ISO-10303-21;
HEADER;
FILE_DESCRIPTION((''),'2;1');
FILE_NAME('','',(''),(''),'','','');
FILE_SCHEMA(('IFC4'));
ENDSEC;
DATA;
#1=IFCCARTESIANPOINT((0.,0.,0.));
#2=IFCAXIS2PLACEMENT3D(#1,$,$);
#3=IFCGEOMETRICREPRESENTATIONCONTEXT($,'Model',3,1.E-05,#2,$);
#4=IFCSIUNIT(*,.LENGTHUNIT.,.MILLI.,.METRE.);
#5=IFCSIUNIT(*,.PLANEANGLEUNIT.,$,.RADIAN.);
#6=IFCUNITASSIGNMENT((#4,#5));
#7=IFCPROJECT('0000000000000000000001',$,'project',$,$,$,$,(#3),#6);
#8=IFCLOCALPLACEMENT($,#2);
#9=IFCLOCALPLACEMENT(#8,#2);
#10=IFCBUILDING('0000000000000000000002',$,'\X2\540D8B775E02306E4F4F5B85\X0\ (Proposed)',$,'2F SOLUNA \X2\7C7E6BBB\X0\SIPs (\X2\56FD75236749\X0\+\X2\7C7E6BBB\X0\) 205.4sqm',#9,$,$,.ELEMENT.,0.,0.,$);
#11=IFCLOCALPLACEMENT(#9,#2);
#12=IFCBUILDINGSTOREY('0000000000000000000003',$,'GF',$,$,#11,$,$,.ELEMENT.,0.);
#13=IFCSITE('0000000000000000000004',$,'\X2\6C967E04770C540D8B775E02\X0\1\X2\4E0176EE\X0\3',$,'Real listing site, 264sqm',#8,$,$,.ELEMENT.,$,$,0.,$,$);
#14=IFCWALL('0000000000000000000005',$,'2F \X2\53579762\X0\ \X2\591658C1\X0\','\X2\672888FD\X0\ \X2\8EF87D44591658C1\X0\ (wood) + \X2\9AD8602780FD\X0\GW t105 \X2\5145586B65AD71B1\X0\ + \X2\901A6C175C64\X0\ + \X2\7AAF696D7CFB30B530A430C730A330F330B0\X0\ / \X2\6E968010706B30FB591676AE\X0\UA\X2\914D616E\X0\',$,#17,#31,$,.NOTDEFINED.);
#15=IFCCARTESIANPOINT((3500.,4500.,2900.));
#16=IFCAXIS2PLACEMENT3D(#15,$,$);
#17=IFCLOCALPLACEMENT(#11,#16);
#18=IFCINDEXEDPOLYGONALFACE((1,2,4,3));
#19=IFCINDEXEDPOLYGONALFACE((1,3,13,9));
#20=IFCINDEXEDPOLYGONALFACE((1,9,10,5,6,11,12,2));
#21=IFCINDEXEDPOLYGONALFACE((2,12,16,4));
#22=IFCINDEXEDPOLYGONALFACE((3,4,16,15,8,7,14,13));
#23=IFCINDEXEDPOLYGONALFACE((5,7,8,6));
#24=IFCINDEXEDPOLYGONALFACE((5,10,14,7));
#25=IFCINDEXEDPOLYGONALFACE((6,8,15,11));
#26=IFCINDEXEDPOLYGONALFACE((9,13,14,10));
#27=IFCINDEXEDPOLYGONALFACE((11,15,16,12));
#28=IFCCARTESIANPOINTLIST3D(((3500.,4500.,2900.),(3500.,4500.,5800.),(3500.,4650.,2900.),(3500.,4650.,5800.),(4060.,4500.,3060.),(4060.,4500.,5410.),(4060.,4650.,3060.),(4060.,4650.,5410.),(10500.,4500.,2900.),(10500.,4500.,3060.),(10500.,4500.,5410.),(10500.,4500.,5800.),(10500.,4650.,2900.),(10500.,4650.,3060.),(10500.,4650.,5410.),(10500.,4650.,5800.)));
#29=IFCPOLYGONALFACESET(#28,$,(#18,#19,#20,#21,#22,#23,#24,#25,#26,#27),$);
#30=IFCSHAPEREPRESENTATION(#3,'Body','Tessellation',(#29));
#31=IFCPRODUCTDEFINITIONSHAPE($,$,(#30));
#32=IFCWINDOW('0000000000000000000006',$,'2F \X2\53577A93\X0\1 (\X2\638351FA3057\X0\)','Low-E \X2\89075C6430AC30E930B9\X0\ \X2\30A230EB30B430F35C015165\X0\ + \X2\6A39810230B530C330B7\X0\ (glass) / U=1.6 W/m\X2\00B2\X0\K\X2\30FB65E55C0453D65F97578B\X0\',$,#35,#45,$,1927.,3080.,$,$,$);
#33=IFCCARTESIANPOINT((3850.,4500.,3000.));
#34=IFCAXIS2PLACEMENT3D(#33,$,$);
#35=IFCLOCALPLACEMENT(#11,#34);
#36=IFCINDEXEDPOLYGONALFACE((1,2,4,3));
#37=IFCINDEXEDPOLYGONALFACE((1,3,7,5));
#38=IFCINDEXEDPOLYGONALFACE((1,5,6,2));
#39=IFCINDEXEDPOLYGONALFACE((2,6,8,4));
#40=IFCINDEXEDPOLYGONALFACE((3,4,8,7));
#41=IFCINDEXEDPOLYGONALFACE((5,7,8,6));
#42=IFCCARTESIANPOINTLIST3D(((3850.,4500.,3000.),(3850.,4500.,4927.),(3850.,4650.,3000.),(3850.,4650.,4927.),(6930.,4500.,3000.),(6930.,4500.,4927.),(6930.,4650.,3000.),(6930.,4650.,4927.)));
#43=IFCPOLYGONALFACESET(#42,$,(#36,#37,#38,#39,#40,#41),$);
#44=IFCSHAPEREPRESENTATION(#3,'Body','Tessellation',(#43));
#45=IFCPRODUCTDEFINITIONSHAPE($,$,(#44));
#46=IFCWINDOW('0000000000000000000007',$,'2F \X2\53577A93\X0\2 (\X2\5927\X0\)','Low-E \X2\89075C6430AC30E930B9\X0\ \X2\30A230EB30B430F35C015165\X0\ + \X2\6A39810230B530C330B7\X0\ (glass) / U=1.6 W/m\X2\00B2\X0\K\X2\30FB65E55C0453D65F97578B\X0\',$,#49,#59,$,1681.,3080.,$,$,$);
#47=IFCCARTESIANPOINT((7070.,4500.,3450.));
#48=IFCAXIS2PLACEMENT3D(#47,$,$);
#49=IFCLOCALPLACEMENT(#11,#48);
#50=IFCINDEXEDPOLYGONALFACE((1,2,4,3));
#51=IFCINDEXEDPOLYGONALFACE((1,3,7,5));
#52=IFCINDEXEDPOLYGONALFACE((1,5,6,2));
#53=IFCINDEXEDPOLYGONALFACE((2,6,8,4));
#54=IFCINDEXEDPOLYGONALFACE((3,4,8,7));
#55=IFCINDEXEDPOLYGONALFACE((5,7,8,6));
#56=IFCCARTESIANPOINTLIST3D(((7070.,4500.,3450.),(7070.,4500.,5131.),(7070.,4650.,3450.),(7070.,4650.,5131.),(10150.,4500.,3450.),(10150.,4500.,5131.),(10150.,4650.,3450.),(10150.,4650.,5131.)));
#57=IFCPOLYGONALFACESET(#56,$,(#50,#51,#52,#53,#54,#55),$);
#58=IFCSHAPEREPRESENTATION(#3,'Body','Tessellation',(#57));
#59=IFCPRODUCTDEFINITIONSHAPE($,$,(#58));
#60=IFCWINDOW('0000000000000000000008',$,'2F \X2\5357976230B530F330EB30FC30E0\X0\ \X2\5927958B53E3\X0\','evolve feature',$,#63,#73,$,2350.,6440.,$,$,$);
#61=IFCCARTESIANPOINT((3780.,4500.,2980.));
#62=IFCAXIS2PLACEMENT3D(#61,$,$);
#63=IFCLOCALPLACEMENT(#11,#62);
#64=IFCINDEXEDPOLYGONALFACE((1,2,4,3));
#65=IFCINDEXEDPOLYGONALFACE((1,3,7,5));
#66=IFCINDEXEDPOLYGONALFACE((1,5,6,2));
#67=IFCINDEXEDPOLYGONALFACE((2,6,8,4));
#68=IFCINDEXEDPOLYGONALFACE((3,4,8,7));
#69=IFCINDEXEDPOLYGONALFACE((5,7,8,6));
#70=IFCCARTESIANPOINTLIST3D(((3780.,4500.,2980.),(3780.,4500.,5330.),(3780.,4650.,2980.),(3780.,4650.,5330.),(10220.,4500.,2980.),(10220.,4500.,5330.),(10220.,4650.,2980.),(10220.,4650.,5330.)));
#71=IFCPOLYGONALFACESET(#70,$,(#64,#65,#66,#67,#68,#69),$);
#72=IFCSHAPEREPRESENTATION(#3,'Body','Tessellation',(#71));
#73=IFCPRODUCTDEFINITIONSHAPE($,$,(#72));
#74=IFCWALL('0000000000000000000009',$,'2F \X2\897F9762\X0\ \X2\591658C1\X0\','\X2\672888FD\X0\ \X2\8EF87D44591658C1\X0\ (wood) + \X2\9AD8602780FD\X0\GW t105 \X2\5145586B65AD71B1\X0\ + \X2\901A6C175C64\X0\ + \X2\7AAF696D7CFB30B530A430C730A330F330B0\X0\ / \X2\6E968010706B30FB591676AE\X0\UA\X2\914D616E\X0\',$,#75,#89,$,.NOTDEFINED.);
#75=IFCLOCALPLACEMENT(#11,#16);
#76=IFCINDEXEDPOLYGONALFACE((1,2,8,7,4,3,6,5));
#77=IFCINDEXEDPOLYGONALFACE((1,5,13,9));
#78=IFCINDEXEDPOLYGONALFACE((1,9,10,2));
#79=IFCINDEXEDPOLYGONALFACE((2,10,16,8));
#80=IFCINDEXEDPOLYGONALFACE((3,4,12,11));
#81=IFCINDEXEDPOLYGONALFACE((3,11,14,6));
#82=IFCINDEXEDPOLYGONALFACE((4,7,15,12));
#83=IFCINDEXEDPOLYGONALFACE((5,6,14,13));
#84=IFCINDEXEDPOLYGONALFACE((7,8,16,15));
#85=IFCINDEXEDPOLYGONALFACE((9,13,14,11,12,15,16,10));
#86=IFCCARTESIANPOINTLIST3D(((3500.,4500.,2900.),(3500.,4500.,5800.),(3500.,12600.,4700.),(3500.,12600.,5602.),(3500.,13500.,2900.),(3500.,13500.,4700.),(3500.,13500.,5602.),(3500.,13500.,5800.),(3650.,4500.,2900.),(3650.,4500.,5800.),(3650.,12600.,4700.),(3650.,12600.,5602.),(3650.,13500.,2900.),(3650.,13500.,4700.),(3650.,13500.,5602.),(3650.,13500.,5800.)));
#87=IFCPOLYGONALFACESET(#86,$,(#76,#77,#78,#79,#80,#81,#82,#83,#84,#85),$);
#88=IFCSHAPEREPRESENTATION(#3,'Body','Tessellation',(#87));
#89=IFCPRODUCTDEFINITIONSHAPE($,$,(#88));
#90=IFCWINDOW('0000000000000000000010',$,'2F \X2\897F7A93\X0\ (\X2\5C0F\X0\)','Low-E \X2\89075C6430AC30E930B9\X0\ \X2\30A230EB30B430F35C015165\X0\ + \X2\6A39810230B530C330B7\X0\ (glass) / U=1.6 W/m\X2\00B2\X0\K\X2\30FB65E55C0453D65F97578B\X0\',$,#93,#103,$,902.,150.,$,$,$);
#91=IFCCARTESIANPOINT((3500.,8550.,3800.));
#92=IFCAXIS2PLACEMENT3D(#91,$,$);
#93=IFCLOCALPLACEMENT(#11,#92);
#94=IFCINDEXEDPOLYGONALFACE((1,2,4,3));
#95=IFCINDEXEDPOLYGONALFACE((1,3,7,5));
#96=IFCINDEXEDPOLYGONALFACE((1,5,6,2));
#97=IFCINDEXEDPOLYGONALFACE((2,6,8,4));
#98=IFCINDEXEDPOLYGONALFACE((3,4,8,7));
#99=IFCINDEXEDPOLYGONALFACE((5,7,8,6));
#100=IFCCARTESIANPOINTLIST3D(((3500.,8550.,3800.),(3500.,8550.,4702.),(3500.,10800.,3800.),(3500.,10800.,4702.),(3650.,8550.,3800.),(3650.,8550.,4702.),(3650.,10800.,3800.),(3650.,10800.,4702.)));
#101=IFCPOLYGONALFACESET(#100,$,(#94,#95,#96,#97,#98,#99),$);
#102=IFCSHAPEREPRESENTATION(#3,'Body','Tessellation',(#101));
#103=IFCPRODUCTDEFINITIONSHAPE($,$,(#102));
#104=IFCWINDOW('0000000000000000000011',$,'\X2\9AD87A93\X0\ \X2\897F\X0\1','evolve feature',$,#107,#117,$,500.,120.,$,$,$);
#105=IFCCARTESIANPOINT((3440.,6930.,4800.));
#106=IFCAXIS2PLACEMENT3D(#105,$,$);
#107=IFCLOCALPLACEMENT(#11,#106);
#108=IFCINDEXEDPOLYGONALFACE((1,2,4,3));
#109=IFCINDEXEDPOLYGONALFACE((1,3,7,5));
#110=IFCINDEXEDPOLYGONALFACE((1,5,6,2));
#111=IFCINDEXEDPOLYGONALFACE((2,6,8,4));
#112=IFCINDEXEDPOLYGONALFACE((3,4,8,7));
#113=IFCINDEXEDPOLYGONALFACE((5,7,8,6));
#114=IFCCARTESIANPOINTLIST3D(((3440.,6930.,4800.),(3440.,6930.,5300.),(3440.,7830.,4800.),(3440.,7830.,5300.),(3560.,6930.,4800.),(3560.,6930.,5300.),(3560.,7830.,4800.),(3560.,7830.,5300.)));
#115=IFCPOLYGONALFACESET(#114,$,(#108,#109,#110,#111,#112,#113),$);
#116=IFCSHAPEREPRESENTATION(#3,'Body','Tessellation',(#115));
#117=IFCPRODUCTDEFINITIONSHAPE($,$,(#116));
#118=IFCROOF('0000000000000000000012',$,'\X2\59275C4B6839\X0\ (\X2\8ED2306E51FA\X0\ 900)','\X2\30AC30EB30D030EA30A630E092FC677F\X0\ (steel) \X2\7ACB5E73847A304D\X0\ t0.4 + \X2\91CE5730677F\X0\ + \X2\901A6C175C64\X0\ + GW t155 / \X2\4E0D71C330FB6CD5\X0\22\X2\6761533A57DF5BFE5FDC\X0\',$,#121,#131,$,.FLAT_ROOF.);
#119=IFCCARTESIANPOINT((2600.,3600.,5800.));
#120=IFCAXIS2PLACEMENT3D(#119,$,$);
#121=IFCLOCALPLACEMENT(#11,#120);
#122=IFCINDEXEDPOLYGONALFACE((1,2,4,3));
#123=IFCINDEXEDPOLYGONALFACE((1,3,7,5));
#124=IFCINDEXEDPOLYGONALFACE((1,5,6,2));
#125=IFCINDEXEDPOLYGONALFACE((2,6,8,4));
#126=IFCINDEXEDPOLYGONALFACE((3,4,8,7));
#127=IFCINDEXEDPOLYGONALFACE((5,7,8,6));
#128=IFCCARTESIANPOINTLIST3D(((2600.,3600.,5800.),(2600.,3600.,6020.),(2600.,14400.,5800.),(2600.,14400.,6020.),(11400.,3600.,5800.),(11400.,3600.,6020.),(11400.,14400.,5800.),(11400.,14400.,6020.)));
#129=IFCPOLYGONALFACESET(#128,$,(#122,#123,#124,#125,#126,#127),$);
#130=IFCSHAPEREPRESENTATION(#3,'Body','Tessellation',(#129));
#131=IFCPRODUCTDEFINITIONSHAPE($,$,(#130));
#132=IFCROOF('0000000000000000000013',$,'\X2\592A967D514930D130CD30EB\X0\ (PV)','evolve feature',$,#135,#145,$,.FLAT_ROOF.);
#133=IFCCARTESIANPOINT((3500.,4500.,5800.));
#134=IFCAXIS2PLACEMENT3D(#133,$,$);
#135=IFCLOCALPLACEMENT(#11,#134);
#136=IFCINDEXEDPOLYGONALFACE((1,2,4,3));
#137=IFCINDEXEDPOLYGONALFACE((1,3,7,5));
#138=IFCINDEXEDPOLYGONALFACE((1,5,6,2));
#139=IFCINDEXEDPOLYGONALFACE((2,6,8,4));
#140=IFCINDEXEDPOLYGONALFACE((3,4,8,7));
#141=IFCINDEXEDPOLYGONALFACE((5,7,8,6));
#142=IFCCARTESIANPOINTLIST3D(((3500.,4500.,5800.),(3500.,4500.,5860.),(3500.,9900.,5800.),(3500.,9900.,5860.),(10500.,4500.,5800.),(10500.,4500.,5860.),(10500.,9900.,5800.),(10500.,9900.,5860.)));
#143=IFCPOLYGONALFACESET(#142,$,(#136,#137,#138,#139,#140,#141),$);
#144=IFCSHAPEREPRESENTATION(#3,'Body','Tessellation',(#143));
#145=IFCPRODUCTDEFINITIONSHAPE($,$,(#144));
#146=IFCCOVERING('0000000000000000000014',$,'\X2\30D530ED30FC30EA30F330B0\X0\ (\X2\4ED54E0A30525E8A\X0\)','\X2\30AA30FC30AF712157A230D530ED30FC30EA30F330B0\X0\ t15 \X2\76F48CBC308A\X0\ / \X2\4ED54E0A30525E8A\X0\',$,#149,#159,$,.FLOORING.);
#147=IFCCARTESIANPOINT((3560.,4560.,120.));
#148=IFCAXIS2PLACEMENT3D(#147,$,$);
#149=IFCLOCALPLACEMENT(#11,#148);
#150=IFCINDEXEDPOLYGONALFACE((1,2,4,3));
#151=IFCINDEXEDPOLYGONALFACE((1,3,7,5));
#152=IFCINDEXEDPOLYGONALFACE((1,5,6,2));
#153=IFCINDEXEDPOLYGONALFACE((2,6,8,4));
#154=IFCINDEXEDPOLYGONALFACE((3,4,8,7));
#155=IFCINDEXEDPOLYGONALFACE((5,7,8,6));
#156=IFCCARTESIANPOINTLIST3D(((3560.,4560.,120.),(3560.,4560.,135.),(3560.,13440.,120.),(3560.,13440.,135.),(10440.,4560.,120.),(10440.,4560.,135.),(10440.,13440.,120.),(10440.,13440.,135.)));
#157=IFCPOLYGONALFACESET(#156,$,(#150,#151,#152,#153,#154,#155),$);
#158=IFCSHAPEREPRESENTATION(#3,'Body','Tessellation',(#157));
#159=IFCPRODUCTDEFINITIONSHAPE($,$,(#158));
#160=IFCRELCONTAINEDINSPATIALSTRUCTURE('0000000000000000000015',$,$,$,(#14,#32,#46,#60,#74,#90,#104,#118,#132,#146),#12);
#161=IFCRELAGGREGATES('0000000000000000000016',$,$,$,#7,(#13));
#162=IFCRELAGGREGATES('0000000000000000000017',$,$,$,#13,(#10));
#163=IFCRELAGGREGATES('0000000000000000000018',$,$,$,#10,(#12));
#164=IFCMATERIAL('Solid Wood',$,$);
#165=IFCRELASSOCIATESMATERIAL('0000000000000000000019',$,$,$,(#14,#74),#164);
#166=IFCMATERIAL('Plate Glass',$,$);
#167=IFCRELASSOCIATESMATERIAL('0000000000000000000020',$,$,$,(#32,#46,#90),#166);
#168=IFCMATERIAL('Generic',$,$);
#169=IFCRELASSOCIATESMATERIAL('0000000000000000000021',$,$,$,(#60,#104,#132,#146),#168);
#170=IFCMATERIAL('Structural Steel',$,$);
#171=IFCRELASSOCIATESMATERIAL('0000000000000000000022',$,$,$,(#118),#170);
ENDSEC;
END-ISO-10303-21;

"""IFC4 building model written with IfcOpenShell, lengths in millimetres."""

from ifc_helpers import new_model, si_unit, frame, frame_2d, origin, place, context, project, spatial, rectangle, extrude, material, element, fill, save


model = new_model("IFC4")

# Units and contexts
model_context = context("Model", 3, precision=1e-05, world=origin())
ifc_project = project(units=[si_unit("LENGTHUNIT", "METRE", prefix="MILLI"), si_unit("PLANEANGLEUNIT", "RADIAN")], contexts=[model_context])

# Site, building, storey
site_placement = place(None, origin())
site = spatial("IfcSite", under=ifc_project, at=site_placement, Name="沖縄県名護市1丁目3", ObjectType="Real listing site, 264sqm", CompositionType="ELEMENT", RefElevation=0.0)
building_placement = place(site_placement, origin())
building = spatial("IfcBuilding", under=site, at=building_placement, Name="名護市の住宅 (Proposed)", ObjectType="2F SOLUNA 籾殻SIPs (国産杉+籾殻) 205.4sqm", CompositionType="ELEMENT", ElevationOfRefHeight=0.0, ElevationOfTerrain=0.0)
storey_placement = place(building_placement, origin())
storey = spatial("IfcBuildingStorey", under=building, at=storey_placement, Name="GF", CompositionType="ELEMENT", Elevation=0.0)

# Shared definitions
ifc_material_1 = material(Name="Solid Wood")

# Shared definitions
ifc_material_2 = material(Name="Plate Glass")
ifc_material_3 = material(Name="Generic")

# Walls, openings, windows
wall_1_placement = place(storey_placement, frame((3500.0, 4500.0, 2900.0)))
wall_1 = element("IfcWall", 1, at=wall_1_placement, inside=storey, material=ifc_material_1, Name="2F 南面 外壁", Description="木製 軸組外壁 (wood) + 高性能GW t105 充填断熱 + 通気層 + 窯業系サイディング / 準耐火・外皮UA配慮", PredefinedType="NOTDEFINED", context=model_context, shape_type="SweptSolid", body=[
    extrude(rectangle(XDim=7000.0, YDim=150.0, at=frame_2d((3500.0, 75.0))), frame((3500.0, 4500.0, 2900.0)), (0.0, 0.0, 1.0), 2900.0),
])
opening_1_placement = place(storey_placement, frame((3850.0, 4500.0, 3000.0)))
opening_1 = element("IfcOpeningElement", 2, at=opening_1_placement, cuts=wall_1, PredefinedType="NOTDEFINED", context=model_context, shape_type="SweptSolid", body=[
    extrude(rectangle(XDim=3080.0, YDim=150.0, at=frame_2d((1540.0, 75.0))), frame((3850.0, 4500.0, 3000.0)), (0.0, 0.0, 1.0), 1927.0),
])
opening_2_placement = place(storey_placement, frame((7070.0, 4500.0, 3450.0)))
opening_2 = element("IfcOpeningElement", 3, at=opening_2_placement, cuts=wall_1, PredefinedType="NOTDEFINED", context=model_context, shape_type="SweptSolid", body=[
    extrude(rectangle(XDim=3080.0, YDim=150.0, at=frame_2d((1540.0, 75.0))), frame((7070.0, 4500.0, 3450.0)), (0.0, 0.0, 1.0), 1681.0),
])
opening_3_placement = place(storey_placement, frame((3780.0, 4500.0, 2980.0)))
opening_3 = element("IfcOpeningElement", 4, at=opening_3_placement, cuts=wall_1, PredefinedType="NOTDEFINED", context=model_context, shape_type="SweptSolid", body=[
    extrude(rectangle(XDim=6440.0, YDim=150.0, at=frame_2d((3220.0, 75.0))), frame((3780.0, 4500.0, 2980.0)), (0.0, 0.0, 1.0), 2350.0),
])
window_1_placement = place(storey_placement, frame((3850.0, 4500.0, 3000.0)))
window_1 = element("IfcWindow", 5, at=window_1_placement, inside=storey, material=ifc_material_2, Name="2F 南窓1 (掃出し)", Description="Low-E 複層ガラス アルゴン封入 + 樹脂サッシ (glass) / U=1.6 W/m²K・日射取得型", OverallHeight=1927.0, OverallWidth=3080.0, context=model_context, shape_type="SweptSolid", body=[
    extrude(rectangle(XDim=3080.0, YDim=150.0, at=frame_2d((1540.0, 75.0))), frame((3850.0, 4500.0, 3000.0)), (0.0, 0.0, 1.0), 1927.0),
])
fill(opening_1, window_1)
window_2_placement = place(storey_placement, frame((7070.0, 4500.0, 3450.0)))
window_2 = element("IfcWindow", 6, at=window_2_placement, inside=storey, material=ifc_material_2, Name="2F 南窓2 (大)", Description="Low-E 複層ガラス アルゴン封入 + 樹脂サッシ (glass) / U=1.6 W/m²K・日射取得型", OverallHeight=1681.0, OverallWidth=3080.0, context=model_context, shape_type="SweptSolid", body=[
    extrude(rectangle(XDim=3080.0, YDim=150.0, at=frame_2d((1540.0, 75.0))), frame((7070.0, 4500.0, 3450.0)), (0.0, 0.0, 1.0), 1681.0),
])
fill(opening_2, window_2)
window_3_placement = place(storey_placement, frame((3780.0, 4500.0, 2980.0)))
window_3 = element("IfcWindow", 7, at=window_3_placement, inside=storey, material=ifc_material_3, Name="2F 南面サンルーム 大開口", Description="evolve feature", OverallHeight=2350.0, OverallWidth=6440.0, context=model_context, shape_type="SweptSolid", body=[
    extrude(rectangle(XDim=6440.0, YDim=150.0, at=frame_2d((3220.0, 75.0))), frame((3780.0, 4500.0, 2980.0)), (0.0, 0.0, 1.0), 2350.0),
])
fill(opening_3, window_3)
wall_2_placement = place(storey_placement, frame((3500.0, 4500.0, 2900.0)))
wall_2 = element("IfcWall", 8, at=wall_2_placement, inside=storey, material=ifc_material_1, Name="2F 西面 外壁", Description="木製 軸組外壁 (wood) + 高性能GW t105 充填断熱 + 通気層 + 窯業系サイディング / 準耐火・外皮UA配慮", PredefinedType="NOTDEFINED", context=model_context, shape_type="SweptSolid", body=[
    extrude(rectangle(XDim=150.0, YDim=9000.0, at=frame_2d((75.0, 4500.0))), frame((3500.0, 4500.0, 2900.0)), (0.0, 0.0, 1.0), 2900.0),
])
opening_4_placement = place(storey_placement, frame((3500.0, 8550.0, 3800.0)))
opening_4 = element("IfcOpeningElement", 9, at=opening_4_placement, cuts=wall_2, PredefinedType="NOTDEFINED", context=model_context, shape_type="SweptSolid", body=[
    extrude(rectangle(XDim=150.0, YDim=2250.0, at=frame_2d((75.0, 1125.0))), frame((3500.0, 8550.0, 3800.0)), (0.0, 0.0, 1.0), 902.0),
])
opening_5_placement = place(storey_placement, frame((3440.0, 6930.0, 4800.0)))
opening_5 = element("IfcOpeningElement", 10, at=opening_5_placement, cuts=wall_2, PredefinedType="NOTDEFINED", context=model_context, shape_type="SweptSolid", body=[
    extrude(rectangle(XDim=120.0, YDim=900.0, at=frame_2d((60.0, 450.0))), frame((3440.0, 6930.0, 4800.0)), (0.0, 0.0, 1.0), 500.0),
])
window_4_placement = place(storey_placement, frame((3500.0, 8550.0, 3800.0)))
window_4 = element("IfcWindow", 11, at=window_4_placement, inside=storey, material=ifc_material_2, Name="2F 西窓 (小)", Description="Low-E 複層ガラス アルゴン封入 + 樹脂サッシ (glass) / U=1.6 W/m²K・日射取得型", OverallHeight=902.0, OverallWidth=150.0, context=model_context, shape_type="SweptSolid", body=[
    extrude(rectangle(XDim=150.0, YDim=2250.0, at=frame_2d((75.0, 1125.0))), frame((3500.0, 8550.0, 3800.0)), (0.0, 0.0, 1.0), 902.0),
])
fill(opening_4, window_4)
window_5_placement = place(storey_placement, frame((3440.0, 6930.0, 4800.0)))
window_5 = element("IfcWindow", 12, at=window_5_placement, inside=storey, material=ifc_material_3, Name="高窓 西1", Description="evolve feature", OverallHeight=500.0, OverallWidth=120.0, context=model_context, shape_type="SweptSolid", body=[
    extrude(rectangle(XDim=120.0, YDim=900.0, at=frame_2d((60.0, 450.0))), frame((3440.0, 6930.0, 4800.0)), (0.0, 0.0, 1.0), 500.0),
])
fill(opening_5, window_5)

# Roofs
ifc_material_4 = material(Name="Structural Steel")
roof_1_placement = place(storey_placement, frame((2600.0, 3600.0, 5800.0)))
element("IfcRoof", 13, at=roof_1_placement, inside=storey, material=ifc_material_4, Name="大屋根 (軒の出 900)", Description="ガルバリウム鋼板 (steel) 立平葺き t0.4 + 野地板 + 通気層 + GW t155 / 不燃・法22条区域対応", PredefinedType="FLAT_ROOF", context=model_context, shape_type="SweptSolid", body=[
    extrude(rectangle(XDim=8800.0, YDim=10800.0, at=frame_2d((4400.0, 5400.0))), frame((2600.0, 3600.0, 5800.0)), (0.0, 0.0, 1.0), 220.0),
])
roof_2_placement = place(storey_placement, frame((3500.0, 4500.0, 5800.0)))
element("IfcRoof", 14, at=roof_2_placement, inside=storey, material=ifc_material_3, Name="太陽光パネル (PV)", Description="evolve feature", PredefinedType="FLAT_ROOF", context=model_context, shape_type="SweptSolid", body=[
    extrude(rectangle(XDim=7000.0, YDim=5400.0, at=frame_2d((3500.0, 2700.0))), frame((3500.0, 4500.0, 5800.0)), (0.0, 0.0, 1.0), 60.0),
])

# Covering
covering_placement = place(storey_placement, frame((3560.0, 4560.0, 120.0)))
element("IfcCovering", 15, at=covering_placement, inside=storey, material=ifc_material_3, Name="フローリング (仕上げ床)", Description="オーク無垢フローリング t15 直貼り / 仕上げ床", PredefinedType="FLOORING", context=model_context, shape_type="SweptSolid", body=[
    extrude(rectangle(XDim=6880.0, YDim=8880.0, at=frame_2d((3440.0, 4440.0))), frame((3560.0, 4560.0, 120.0)), (0.0, 0.0, 1.0), 15.0),
])

save(model, "model.ifc")
